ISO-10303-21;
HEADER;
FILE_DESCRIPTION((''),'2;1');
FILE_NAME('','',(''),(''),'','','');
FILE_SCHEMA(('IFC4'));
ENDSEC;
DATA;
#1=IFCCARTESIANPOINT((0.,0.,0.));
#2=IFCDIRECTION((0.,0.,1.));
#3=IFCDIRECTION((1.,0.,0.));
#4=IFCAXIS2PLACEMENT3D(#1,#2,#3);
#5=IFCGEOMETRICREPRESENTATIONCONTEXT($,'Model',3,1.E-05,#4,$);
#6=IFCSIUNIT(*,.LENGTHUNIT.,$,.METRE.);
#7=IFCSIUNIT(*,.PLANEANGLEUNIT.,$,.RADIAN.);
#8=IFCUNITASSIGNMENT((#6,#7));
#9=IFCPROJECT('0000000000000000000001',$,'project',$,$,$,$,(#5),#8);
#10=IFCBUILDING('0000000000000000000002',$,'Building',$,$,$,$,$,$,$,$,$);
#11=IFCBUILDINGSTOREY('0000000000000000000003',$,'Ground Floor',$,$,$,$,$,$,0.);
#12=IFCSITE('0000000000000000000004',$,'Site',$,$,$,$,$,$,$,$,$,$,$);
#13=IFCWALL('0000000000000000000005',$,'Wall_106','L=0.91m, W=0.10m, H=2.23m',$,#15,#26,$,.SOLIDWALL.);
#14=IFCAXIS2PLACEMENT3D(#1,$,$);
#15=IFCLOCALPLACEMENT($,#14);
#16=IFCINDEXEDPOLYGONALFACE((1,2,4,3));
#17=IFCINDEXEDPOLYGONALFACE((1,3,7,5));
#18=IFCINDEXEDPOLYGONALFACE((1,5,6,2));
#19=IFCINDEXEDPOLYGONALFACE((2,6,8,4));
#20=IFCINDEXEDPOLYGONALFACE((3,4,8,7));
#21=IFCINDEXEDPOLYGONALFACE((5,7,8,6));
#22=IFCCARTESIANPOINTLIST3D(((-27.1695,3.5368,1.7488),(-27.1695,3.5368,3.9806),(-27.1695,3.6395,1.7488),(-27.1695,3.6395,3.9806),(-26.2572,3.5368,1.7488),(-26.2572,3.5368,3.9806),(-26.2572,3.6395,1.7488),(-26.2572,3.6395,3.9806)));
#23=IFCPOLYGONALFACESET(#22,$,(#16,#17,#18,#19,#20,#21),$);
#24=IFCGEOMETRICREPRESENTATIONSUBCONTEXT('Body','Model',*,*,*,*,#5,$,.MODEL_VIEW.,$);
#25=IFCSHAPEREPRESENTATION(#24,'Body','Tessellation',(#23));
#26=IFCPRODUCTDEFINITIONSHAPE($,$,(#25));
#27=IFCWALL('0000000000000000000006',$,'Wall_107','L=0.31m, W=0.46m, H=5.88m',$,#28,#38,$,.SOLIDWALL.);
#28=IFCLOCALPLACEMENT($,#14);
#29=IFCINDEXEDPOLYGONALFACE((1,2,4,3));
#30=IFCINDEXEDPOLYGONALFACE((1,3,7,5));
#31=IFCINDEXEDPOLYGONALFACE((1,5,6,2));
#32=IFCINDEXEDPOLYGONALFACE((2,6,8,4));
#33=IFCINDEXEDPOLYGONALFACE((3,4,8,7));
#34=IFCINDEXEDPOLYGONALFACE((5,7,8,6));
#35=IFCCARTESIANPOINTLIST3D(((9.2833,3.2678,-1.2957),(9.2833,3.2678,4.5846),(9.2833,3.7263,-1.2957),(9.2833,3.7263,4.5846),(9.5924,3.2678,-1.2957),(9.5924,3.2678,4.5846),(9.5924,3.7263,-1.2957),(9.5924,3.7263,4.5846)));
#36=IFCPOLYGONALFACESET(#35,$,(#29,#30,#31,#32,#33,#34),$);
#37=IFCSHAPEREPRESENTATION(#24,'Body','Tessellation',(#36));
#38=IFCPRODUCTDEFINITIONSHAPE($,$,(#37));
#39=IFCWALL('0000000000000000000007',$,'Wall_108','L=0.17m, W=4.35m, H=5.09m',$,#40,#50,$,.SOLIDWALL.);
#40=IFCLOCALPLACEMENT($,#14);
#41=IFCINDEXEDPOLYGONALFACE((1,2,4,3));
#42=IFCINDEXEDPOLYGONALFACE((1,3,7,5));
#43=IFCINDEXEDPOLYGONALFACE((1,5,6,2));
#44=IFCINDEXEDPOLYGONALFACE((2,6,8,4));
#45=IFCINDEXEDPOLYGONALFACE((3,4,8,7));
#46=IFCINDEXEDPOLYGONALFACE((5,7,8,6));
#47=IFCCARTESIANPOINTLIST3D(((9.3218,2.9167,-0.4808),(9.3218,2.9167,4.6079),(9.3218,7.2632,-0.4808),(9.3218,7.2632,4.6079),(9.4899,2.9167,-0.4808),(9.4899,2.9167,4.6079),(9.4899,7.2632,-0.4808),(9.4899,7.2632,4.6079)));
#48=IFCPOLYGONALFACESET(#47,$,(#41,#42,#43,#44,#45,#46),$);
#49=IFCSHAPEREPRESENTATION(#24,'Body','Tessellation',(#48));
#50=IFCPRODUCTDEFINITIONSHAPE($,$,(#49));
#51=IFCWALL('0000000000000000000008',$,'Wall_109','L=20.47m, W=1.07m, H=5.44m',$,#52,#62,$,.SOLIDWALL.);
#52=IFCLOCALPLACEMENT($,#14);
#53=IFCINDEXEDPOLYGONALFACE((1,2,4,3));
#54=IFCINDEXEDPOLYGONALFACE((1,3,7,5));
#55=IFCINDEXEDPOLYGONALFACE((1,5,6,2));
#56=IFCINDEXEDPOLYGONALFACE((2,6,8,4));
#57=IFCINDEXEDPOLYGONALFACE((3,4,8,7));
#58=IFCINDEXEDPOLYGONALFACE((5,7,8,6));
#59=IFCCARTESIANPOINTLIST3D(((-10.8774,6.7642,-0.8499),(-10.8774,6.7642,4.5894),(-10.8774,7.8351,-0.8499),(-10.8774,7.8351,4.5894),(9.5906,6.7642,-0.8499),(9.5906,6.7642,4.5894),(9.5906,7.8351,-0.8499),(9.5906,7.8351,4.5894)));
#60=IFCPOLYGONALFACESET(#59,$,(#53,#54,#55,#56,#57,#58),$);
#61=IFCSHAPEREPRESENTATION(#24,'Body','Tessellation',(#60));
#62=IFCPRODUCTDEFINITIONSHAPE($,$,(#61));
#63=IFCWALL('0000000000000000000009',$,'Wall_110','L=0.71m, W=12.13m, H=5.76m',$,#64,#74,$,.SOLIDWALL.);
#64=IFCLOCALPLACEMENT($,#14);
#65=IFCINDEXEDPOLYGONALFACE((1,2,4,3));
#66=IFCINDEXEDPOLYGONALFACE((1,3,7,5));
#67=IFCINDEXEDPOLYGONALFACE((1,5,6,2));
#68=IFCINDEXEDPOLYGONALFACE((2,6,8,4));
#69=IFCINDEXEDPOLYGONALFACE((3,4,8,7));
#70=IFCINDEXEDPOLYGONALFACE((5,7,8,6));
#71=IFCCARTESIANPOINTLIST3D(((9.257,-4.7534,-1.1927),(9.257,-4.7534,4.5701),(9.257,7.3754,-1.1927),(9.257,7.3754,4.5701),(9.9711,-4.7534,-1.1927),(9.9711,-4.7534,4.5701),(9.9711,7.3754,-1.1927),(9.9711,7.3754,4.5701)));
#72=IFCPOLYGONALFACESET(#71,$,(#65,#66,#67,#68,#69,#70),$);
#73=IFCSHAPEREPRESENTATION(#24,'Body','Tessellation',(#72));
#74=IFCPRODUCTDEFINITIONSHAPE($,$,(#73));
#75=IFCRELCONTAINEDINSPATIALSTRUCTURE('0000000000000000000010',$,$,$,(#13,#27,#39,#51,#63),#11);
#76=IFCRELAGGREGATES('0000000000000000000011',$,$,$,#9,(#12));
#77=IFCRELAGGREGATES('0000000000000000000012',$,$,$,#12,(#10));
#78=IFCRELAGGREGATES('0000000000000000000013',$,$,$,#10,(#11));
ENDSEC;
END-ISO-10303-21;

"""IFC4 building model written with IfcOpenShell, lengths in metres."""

from ifc_helpers import new_model, si_unit, frame, origin_with_axes, origin_2d, context, subcontext, project, spatial, rectangle, extrude, element, save


model = new_model("IFC4")

# Units and contexts
model_context = context("Model", 3, precision=1e-05, world=origin_with_axes())
body_context = subcontext(model_context, "Body", "Model", "MODEL_VIEW")
ifc_project = project(units=[si_unit("LENGTHUNIT", "METRE"), si_unit("PLANEANGLEUNIT", "RADIAN")], contexts=[model_context])

# Site, building, storey
site = spatial("IfcSite", under=ifc_project, Name="Site")
building = spatial("IfcBuilding", under=site, Name="Building")
storey = spatial("IfcBuildingStorey", under=building, Name="Ground Floor", Elevation=0.0)

# Walls
element("IfcWall", 1, inside=storey, Name="Wall_106", Description="L=0.91m, W=0.10m, H=2.23m", PredefinedType="SOLIDWALL", context=body_context, shape_type="SweptSolid", body=[
    extrude(rectangle(XDim=0.9124, YDim=0.1028, at=origin_2d()), frame((-26.7134, 3.5881, 1.7488), z_axis=(0.0, 0.0, 1.0), x_axis=(1.0, 0.0, 0.0)), (0.0, 0.0, 1.0), 2.2317),
])
element("IfcWall", 2, inside=storey, Name="Wall_107", Description="L=0.31m, W=0.46m, H=5.88m", PredefinedType="SOLIDWALL", context=body_context, shape_type="SweptSolid", body=[
    extrude(rectangle(XDim=0.3092, YDim=0.4585, at=origin_2d()), frame((9.4379, 3.497, -1.2957), z_axis=(0.0, 0.0, 1.0), x_axis=(1.0, 0.0, 0.0)), (0.0, 0.0, 1.0), 5.8803),
])
element("IfcWall", 3, inside=storey, Name="Wall_108", Description="L=0.17m, W=4.35m, H=5.09m", PredefinedType="SOLIDWALL", context=body_context, shape_type="SweptSolid", body=[
    extrude(rectangle(XDim=0.1681, YDim=4.3465, at=origin_2d()), frame((9.4059, 5.09, -0.4808), z_axis=(0.0, 0.0, 1.0), x_axis=(1.0, 0.0, 0.0)), (0.0, 0.0, 1.0), 5.0886),
])
element("IfcWall", 4, inside=storey, Name="Wall_109", Description="L=20.47m, W=1.07m, H=5.44m", PredefinedType="SOLIDWALL", context=body_context, shape_type="SweptSolid", body=[
    extrude(rectangle(XDim=20.468, YDim=1.0709, at=origin_2d()), frame((-0.6434, 7.2996, -0.8499), z_axis=(0.0, 0.0, 1.0), x_axis=(1.0, 0.0, 0.0)), (0.0, 0.0, 1.0), 5.4393),
])
element("IfcWall", 5, inside=storey, Name="Wall_110", Description="L=0.71m, W=12.13m, H=5.76m", PredefinedType="SOLIDWALL", context=body_context, shape_type="SweptSolid", body=[
    extrude(rectangle(XDim=0.7141, YDim=12.1288, at=origin_2d()), frame((9.614, 1.311, -1.1927), z_axis=(0.0, 0.0, 1.0), x_axis=(1.0, 0.0, 0.0)), (0.0, 0.0, 1.0), 5.7628),
])

save(model, "model.ifc")
